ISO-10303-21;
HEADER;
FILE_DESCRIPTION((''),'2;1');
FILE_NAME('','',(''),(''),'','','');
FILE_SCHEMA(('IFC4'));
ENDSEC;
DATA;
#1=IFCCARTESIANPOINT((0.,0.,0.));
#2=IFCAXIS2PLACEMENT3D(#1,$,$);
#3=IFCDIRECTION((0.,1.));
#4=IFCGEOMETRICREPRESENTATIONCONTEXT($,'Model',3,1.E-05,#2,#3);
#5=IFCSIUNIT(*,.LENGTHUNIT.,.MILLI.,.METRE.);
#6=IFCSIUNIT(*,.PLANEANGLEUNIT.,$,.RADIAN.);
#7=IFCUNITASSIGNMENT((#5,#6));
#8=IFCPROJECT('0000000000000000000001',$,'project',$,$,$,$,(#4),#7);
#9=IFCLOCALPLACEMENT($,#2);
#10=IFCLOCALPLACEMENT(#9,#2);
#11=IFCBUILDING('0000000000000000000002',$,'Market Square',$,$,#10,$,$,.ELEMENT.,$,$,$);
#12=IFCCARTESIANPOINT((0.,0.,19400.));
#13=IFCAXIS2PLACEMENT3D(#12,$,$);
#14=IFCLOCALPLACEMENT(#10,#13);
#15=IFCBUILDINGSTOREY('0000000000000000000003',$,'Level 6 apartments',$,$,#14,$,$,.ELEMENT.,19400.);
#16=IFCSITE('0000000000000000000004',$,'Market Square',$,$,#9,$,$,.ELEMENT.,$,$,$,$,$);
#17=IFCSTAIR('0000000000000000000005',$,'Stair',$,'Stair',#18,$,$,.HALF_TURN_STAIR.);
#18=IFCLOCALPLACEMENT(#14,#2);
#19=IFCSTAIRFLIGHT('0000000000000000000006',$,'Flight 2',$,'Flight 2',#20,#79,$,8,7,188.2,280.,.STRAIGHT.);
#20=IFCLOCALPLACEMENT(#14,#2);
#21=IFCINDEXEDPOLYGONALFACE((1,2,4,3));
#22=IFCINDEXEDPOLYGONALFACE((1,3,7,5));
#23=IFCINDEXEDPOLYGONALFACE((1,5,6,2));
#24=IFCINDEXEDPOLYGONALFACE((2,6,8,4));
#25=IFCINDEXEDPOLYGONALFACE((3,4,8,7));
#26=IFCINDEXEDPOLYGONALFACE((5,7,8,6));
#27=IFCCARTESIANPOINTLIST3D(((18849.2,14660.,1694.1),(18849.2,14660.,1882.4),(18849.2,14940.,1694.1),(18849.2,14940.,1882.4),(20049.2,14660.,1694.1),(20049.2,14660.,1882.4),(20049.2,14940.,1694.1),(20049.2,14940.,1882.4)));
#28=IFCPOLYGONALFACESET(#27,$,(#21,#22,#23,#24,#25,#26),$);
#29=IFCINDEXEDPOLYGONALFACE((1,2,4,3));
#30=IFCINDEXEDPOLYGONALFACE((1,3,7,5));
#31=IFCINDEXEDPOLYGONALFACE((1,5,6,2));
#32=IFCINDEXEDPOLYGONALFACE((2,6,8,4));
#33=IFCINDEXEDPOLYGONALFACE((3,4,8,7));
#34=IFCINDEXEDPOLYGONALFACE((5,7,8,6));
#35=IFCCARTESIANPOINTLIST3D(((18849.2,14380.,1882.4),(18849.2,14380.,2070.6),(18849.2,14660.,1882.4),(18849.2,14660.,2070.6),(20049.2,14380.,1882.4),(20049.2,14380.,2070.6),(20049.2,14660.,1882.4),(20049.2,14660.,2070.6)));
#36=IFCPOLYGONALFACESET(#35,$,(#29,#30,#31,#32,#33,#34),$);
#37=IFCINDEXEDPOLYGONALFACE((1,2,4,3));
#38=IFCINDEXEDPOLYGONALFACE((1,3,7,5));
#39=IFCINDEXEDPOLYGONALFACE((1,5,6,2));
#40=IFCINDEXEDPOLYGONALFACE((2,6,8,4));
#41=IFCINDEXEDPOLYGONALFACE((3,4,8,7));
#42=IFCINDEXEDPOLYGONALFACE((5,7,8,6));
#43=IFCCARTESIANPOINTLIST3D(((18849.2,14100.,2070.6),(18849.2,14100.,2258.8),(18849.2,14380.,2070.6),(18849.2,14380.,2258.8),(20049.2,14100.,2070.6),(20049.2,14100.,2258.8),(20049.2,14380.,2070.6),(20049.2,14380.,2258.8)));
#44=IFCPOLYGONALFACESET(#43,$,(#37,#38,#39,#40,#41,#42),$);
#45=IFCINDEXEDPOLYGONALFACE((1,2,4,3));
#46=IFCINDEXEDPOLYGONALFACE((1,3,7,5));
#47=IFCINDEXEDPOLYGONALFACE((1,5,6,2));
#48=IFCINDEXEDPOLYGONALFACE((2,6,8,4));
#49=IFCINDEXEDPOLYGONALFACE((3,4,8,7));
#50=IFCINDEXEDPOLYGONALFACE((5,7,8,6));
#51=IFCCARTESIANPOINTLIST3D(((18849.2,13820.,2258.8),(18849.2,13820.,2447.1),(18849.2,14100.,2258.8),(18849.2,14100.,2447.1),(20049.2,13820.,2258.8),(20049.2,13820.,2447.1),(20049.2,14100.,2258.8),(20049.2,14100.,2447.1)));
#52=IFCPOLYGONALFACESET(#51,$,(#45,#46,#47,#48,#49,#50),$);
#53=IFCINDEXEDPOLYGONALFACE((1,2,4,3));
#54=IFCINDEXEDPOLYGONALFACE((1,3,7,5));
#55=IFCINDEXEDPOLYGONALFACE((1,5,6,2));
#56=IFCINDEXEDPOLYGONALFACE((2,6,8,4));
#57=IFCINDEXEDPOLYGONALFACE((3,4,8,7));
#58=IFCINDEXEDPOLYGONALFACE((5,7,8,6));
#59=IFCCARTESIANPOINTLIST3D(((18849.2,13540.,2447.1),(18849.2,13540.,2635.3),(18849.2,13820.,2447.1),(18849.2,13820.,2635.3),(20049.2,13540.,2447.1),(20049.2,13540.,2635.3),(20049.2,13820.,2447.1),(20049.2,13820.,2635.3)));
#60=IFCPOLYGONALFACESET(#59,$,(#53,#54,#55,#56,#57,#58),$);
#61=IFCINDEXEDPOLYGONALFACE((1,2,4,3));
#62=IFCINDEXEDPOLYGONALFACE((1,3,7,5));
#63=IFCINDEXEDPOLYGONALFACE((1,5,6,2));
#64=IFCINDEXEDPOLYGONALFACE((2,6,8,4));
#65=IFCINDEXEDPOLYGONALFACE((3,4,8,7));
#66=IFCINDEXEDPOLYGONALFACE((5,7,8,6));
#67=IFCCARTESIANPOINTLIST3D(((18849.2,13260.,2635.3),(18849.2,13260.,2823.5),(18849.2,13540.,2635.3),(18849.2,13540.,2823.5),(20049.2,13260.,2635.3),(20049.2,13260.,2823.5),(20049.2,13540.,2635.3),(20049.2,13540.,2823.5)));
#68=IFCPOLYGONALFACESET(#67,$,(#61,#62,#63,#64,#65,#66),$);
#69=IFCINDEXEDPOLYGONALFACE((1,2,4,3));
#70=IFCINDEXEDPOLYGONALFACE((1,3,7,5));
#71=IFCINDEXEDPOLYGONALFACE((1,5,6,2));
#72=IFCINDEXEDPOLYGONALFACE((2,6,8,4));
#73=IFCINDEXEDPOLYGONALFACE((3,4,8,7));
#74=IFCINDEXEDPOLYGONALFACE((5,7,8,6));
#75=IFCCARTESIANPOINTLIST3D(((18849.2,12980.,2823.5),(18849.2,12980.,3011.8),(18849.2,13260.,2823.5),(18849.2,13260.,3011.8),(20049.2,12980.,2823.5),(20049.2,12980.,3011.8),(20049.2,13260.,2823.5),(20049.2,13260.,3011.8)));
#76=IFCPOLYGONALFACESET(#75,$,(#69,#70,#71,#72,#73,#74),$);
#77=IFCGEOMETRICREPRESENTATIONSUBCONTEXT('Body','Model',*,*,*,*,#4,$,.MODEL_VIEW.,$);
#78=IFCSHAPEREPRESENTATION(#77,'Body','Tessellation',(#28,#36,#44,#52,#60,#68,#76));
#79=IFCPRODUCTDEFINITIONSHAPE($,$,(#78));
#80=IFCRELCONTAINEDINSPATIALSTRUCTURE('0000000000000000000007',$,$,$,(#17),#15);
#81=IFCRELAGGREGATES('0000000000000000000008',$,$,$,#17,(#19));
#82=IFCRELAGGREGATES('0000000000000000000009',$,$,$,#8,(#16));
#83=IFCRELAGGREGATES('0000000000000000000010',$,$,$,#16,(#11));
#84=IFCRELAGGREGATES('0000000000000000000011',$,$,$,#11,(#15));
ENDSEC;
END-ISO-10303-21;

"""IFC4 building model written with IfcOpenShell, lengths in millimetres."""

from ifc_helpers import new_model, si_unit, direction, frame, origin, origin_with_axes, place, context, subcontext, project, spatial, polyline, outline, extrude, element, aggregate, save


model = new_model("IFC4")

# Units and contexts
model_context = context("Model", 3, precision=1e-05, world=origin(), true_north=direction((0.0, 1.0)))
body_context = subcontext(model_context, "Body", "Model", "MODEL_VIEW")
ifc_project = project(units=[si_unit("LENGTHUNIT", "METRE", prefix="MILLI"), si_unit("PLANEANGLEUNIT", "RADIAN")], contexts=[model_context])

# Site, building, storey
site_placement = place(None, origin())
site = spatial("IfcSite", under=ifc_project, at=site_placement, Name="Market Square", CompositionType="ELEMENT")
building_placement = place(site_placement, origin())
building = spatial("IfcBuilding", under=site, at=building_placement, Name="Market Square", CompositionType="ELEMENT")
storey_placement = place(building_placement, frame((0.0, 0.0, 19400.0)))
storey = spatial("IfcBuildingStorey", under=building, at=storey_placement, Name="Level 6 apartments", CompositionType="ELEMENT", Elevation=19400.0)

# Stair
stair_placement = place(storey_placement, origin_with_axes())
stair = element("IfcStair", 1, at=stair_placement, inside=storey, Name="Stair", ObjectType="Stair", PredefinedType="HALF_TURN_STAIR")

# Stair flight
stair_flight_placement = place(storey_placement, origin_with_axes())
stair_flight = element("IfcStairFlight", 2, at=stair_flight_placement, Name="Flight 2", ObjectType="Flight 2", NumberOfRisers=8, NumberOfTreads=7, PredefinedType="STRAIGHT", RiserHeight=188.2, TreadLength=280.0, context=body_context, shape_type="SweptSolid", body=[
    extrude(outline(polyline([(20049.2, 14660.0), (20049.2, 14940.0), (18849.2, 14940.0), (18849.2, 14660.0), (20049.2, 14660.0)])), frame((0.0, 0.0, 1694.1)), (0.0, 0.0, 1.0), 188.2),
    extrude(outline(polyline([(20049.2, 14380.0), (20049.2, 14660.0), (18849.2, 14660.0), (18849.2, 14380.0), (20049.2, 14380.0)])), frame((0.0, 0.0, 1882.4)), (0.0, 0.0, 1.0), 188.2),
    extrude(outline(polyline([(20049.2, 14100.0), (20049.2, 14380.0), (18849.2, 14380.0), (18849.2, 14100.0), (20049.2, 14100.0)])), frame((0.0, 0.0, 2070.6)), (0.0, 0.0, 1.0), 188.2),
    extrude(outline(polyline([(20049.2, 13820.0), (20049.2, 14100.0), (18849.2, 14100.0), (18849.2, 13820.0), (20049.2, 13820.0)])), frame((0.0, 0.0, 2258.8)), (0.0, 0.0, 1.0), 188.2),
    extrude(outline(polyline([(20049.2, 13540.0), (20049.2, 13820.0), (18849.2, 13820.0), (18849.2, 13540.0), (20049.2, 13540.0)])), frame((0.0, 0.0, 2447.1)), (0.0, 0.0, 1.0), 188.2),
    extrude(outline(polyline([(20049.2, 13260.0), (20049.2, 13540.0), (18849.2, 13540.0), (18849.2, 13260.0), (20049.2, 13260.0)])), frame((0.0, 0.0, 2635.3)), (0.0, 0.0, 1.0), 188.2),
    extrude(outline(polyline([(20049.2, 12980.0), (20049.2, 13260.0), (18849.2, 13260.0), (18849.2, 12980.0), (20049.2, 12980.0)])), frame((0.0, 0.0, 2823.5)), (0.0, 0.0, 1.0), 188.2),
])

aggregate(stair, [stair_flight])

save(model, "model.ifc")
